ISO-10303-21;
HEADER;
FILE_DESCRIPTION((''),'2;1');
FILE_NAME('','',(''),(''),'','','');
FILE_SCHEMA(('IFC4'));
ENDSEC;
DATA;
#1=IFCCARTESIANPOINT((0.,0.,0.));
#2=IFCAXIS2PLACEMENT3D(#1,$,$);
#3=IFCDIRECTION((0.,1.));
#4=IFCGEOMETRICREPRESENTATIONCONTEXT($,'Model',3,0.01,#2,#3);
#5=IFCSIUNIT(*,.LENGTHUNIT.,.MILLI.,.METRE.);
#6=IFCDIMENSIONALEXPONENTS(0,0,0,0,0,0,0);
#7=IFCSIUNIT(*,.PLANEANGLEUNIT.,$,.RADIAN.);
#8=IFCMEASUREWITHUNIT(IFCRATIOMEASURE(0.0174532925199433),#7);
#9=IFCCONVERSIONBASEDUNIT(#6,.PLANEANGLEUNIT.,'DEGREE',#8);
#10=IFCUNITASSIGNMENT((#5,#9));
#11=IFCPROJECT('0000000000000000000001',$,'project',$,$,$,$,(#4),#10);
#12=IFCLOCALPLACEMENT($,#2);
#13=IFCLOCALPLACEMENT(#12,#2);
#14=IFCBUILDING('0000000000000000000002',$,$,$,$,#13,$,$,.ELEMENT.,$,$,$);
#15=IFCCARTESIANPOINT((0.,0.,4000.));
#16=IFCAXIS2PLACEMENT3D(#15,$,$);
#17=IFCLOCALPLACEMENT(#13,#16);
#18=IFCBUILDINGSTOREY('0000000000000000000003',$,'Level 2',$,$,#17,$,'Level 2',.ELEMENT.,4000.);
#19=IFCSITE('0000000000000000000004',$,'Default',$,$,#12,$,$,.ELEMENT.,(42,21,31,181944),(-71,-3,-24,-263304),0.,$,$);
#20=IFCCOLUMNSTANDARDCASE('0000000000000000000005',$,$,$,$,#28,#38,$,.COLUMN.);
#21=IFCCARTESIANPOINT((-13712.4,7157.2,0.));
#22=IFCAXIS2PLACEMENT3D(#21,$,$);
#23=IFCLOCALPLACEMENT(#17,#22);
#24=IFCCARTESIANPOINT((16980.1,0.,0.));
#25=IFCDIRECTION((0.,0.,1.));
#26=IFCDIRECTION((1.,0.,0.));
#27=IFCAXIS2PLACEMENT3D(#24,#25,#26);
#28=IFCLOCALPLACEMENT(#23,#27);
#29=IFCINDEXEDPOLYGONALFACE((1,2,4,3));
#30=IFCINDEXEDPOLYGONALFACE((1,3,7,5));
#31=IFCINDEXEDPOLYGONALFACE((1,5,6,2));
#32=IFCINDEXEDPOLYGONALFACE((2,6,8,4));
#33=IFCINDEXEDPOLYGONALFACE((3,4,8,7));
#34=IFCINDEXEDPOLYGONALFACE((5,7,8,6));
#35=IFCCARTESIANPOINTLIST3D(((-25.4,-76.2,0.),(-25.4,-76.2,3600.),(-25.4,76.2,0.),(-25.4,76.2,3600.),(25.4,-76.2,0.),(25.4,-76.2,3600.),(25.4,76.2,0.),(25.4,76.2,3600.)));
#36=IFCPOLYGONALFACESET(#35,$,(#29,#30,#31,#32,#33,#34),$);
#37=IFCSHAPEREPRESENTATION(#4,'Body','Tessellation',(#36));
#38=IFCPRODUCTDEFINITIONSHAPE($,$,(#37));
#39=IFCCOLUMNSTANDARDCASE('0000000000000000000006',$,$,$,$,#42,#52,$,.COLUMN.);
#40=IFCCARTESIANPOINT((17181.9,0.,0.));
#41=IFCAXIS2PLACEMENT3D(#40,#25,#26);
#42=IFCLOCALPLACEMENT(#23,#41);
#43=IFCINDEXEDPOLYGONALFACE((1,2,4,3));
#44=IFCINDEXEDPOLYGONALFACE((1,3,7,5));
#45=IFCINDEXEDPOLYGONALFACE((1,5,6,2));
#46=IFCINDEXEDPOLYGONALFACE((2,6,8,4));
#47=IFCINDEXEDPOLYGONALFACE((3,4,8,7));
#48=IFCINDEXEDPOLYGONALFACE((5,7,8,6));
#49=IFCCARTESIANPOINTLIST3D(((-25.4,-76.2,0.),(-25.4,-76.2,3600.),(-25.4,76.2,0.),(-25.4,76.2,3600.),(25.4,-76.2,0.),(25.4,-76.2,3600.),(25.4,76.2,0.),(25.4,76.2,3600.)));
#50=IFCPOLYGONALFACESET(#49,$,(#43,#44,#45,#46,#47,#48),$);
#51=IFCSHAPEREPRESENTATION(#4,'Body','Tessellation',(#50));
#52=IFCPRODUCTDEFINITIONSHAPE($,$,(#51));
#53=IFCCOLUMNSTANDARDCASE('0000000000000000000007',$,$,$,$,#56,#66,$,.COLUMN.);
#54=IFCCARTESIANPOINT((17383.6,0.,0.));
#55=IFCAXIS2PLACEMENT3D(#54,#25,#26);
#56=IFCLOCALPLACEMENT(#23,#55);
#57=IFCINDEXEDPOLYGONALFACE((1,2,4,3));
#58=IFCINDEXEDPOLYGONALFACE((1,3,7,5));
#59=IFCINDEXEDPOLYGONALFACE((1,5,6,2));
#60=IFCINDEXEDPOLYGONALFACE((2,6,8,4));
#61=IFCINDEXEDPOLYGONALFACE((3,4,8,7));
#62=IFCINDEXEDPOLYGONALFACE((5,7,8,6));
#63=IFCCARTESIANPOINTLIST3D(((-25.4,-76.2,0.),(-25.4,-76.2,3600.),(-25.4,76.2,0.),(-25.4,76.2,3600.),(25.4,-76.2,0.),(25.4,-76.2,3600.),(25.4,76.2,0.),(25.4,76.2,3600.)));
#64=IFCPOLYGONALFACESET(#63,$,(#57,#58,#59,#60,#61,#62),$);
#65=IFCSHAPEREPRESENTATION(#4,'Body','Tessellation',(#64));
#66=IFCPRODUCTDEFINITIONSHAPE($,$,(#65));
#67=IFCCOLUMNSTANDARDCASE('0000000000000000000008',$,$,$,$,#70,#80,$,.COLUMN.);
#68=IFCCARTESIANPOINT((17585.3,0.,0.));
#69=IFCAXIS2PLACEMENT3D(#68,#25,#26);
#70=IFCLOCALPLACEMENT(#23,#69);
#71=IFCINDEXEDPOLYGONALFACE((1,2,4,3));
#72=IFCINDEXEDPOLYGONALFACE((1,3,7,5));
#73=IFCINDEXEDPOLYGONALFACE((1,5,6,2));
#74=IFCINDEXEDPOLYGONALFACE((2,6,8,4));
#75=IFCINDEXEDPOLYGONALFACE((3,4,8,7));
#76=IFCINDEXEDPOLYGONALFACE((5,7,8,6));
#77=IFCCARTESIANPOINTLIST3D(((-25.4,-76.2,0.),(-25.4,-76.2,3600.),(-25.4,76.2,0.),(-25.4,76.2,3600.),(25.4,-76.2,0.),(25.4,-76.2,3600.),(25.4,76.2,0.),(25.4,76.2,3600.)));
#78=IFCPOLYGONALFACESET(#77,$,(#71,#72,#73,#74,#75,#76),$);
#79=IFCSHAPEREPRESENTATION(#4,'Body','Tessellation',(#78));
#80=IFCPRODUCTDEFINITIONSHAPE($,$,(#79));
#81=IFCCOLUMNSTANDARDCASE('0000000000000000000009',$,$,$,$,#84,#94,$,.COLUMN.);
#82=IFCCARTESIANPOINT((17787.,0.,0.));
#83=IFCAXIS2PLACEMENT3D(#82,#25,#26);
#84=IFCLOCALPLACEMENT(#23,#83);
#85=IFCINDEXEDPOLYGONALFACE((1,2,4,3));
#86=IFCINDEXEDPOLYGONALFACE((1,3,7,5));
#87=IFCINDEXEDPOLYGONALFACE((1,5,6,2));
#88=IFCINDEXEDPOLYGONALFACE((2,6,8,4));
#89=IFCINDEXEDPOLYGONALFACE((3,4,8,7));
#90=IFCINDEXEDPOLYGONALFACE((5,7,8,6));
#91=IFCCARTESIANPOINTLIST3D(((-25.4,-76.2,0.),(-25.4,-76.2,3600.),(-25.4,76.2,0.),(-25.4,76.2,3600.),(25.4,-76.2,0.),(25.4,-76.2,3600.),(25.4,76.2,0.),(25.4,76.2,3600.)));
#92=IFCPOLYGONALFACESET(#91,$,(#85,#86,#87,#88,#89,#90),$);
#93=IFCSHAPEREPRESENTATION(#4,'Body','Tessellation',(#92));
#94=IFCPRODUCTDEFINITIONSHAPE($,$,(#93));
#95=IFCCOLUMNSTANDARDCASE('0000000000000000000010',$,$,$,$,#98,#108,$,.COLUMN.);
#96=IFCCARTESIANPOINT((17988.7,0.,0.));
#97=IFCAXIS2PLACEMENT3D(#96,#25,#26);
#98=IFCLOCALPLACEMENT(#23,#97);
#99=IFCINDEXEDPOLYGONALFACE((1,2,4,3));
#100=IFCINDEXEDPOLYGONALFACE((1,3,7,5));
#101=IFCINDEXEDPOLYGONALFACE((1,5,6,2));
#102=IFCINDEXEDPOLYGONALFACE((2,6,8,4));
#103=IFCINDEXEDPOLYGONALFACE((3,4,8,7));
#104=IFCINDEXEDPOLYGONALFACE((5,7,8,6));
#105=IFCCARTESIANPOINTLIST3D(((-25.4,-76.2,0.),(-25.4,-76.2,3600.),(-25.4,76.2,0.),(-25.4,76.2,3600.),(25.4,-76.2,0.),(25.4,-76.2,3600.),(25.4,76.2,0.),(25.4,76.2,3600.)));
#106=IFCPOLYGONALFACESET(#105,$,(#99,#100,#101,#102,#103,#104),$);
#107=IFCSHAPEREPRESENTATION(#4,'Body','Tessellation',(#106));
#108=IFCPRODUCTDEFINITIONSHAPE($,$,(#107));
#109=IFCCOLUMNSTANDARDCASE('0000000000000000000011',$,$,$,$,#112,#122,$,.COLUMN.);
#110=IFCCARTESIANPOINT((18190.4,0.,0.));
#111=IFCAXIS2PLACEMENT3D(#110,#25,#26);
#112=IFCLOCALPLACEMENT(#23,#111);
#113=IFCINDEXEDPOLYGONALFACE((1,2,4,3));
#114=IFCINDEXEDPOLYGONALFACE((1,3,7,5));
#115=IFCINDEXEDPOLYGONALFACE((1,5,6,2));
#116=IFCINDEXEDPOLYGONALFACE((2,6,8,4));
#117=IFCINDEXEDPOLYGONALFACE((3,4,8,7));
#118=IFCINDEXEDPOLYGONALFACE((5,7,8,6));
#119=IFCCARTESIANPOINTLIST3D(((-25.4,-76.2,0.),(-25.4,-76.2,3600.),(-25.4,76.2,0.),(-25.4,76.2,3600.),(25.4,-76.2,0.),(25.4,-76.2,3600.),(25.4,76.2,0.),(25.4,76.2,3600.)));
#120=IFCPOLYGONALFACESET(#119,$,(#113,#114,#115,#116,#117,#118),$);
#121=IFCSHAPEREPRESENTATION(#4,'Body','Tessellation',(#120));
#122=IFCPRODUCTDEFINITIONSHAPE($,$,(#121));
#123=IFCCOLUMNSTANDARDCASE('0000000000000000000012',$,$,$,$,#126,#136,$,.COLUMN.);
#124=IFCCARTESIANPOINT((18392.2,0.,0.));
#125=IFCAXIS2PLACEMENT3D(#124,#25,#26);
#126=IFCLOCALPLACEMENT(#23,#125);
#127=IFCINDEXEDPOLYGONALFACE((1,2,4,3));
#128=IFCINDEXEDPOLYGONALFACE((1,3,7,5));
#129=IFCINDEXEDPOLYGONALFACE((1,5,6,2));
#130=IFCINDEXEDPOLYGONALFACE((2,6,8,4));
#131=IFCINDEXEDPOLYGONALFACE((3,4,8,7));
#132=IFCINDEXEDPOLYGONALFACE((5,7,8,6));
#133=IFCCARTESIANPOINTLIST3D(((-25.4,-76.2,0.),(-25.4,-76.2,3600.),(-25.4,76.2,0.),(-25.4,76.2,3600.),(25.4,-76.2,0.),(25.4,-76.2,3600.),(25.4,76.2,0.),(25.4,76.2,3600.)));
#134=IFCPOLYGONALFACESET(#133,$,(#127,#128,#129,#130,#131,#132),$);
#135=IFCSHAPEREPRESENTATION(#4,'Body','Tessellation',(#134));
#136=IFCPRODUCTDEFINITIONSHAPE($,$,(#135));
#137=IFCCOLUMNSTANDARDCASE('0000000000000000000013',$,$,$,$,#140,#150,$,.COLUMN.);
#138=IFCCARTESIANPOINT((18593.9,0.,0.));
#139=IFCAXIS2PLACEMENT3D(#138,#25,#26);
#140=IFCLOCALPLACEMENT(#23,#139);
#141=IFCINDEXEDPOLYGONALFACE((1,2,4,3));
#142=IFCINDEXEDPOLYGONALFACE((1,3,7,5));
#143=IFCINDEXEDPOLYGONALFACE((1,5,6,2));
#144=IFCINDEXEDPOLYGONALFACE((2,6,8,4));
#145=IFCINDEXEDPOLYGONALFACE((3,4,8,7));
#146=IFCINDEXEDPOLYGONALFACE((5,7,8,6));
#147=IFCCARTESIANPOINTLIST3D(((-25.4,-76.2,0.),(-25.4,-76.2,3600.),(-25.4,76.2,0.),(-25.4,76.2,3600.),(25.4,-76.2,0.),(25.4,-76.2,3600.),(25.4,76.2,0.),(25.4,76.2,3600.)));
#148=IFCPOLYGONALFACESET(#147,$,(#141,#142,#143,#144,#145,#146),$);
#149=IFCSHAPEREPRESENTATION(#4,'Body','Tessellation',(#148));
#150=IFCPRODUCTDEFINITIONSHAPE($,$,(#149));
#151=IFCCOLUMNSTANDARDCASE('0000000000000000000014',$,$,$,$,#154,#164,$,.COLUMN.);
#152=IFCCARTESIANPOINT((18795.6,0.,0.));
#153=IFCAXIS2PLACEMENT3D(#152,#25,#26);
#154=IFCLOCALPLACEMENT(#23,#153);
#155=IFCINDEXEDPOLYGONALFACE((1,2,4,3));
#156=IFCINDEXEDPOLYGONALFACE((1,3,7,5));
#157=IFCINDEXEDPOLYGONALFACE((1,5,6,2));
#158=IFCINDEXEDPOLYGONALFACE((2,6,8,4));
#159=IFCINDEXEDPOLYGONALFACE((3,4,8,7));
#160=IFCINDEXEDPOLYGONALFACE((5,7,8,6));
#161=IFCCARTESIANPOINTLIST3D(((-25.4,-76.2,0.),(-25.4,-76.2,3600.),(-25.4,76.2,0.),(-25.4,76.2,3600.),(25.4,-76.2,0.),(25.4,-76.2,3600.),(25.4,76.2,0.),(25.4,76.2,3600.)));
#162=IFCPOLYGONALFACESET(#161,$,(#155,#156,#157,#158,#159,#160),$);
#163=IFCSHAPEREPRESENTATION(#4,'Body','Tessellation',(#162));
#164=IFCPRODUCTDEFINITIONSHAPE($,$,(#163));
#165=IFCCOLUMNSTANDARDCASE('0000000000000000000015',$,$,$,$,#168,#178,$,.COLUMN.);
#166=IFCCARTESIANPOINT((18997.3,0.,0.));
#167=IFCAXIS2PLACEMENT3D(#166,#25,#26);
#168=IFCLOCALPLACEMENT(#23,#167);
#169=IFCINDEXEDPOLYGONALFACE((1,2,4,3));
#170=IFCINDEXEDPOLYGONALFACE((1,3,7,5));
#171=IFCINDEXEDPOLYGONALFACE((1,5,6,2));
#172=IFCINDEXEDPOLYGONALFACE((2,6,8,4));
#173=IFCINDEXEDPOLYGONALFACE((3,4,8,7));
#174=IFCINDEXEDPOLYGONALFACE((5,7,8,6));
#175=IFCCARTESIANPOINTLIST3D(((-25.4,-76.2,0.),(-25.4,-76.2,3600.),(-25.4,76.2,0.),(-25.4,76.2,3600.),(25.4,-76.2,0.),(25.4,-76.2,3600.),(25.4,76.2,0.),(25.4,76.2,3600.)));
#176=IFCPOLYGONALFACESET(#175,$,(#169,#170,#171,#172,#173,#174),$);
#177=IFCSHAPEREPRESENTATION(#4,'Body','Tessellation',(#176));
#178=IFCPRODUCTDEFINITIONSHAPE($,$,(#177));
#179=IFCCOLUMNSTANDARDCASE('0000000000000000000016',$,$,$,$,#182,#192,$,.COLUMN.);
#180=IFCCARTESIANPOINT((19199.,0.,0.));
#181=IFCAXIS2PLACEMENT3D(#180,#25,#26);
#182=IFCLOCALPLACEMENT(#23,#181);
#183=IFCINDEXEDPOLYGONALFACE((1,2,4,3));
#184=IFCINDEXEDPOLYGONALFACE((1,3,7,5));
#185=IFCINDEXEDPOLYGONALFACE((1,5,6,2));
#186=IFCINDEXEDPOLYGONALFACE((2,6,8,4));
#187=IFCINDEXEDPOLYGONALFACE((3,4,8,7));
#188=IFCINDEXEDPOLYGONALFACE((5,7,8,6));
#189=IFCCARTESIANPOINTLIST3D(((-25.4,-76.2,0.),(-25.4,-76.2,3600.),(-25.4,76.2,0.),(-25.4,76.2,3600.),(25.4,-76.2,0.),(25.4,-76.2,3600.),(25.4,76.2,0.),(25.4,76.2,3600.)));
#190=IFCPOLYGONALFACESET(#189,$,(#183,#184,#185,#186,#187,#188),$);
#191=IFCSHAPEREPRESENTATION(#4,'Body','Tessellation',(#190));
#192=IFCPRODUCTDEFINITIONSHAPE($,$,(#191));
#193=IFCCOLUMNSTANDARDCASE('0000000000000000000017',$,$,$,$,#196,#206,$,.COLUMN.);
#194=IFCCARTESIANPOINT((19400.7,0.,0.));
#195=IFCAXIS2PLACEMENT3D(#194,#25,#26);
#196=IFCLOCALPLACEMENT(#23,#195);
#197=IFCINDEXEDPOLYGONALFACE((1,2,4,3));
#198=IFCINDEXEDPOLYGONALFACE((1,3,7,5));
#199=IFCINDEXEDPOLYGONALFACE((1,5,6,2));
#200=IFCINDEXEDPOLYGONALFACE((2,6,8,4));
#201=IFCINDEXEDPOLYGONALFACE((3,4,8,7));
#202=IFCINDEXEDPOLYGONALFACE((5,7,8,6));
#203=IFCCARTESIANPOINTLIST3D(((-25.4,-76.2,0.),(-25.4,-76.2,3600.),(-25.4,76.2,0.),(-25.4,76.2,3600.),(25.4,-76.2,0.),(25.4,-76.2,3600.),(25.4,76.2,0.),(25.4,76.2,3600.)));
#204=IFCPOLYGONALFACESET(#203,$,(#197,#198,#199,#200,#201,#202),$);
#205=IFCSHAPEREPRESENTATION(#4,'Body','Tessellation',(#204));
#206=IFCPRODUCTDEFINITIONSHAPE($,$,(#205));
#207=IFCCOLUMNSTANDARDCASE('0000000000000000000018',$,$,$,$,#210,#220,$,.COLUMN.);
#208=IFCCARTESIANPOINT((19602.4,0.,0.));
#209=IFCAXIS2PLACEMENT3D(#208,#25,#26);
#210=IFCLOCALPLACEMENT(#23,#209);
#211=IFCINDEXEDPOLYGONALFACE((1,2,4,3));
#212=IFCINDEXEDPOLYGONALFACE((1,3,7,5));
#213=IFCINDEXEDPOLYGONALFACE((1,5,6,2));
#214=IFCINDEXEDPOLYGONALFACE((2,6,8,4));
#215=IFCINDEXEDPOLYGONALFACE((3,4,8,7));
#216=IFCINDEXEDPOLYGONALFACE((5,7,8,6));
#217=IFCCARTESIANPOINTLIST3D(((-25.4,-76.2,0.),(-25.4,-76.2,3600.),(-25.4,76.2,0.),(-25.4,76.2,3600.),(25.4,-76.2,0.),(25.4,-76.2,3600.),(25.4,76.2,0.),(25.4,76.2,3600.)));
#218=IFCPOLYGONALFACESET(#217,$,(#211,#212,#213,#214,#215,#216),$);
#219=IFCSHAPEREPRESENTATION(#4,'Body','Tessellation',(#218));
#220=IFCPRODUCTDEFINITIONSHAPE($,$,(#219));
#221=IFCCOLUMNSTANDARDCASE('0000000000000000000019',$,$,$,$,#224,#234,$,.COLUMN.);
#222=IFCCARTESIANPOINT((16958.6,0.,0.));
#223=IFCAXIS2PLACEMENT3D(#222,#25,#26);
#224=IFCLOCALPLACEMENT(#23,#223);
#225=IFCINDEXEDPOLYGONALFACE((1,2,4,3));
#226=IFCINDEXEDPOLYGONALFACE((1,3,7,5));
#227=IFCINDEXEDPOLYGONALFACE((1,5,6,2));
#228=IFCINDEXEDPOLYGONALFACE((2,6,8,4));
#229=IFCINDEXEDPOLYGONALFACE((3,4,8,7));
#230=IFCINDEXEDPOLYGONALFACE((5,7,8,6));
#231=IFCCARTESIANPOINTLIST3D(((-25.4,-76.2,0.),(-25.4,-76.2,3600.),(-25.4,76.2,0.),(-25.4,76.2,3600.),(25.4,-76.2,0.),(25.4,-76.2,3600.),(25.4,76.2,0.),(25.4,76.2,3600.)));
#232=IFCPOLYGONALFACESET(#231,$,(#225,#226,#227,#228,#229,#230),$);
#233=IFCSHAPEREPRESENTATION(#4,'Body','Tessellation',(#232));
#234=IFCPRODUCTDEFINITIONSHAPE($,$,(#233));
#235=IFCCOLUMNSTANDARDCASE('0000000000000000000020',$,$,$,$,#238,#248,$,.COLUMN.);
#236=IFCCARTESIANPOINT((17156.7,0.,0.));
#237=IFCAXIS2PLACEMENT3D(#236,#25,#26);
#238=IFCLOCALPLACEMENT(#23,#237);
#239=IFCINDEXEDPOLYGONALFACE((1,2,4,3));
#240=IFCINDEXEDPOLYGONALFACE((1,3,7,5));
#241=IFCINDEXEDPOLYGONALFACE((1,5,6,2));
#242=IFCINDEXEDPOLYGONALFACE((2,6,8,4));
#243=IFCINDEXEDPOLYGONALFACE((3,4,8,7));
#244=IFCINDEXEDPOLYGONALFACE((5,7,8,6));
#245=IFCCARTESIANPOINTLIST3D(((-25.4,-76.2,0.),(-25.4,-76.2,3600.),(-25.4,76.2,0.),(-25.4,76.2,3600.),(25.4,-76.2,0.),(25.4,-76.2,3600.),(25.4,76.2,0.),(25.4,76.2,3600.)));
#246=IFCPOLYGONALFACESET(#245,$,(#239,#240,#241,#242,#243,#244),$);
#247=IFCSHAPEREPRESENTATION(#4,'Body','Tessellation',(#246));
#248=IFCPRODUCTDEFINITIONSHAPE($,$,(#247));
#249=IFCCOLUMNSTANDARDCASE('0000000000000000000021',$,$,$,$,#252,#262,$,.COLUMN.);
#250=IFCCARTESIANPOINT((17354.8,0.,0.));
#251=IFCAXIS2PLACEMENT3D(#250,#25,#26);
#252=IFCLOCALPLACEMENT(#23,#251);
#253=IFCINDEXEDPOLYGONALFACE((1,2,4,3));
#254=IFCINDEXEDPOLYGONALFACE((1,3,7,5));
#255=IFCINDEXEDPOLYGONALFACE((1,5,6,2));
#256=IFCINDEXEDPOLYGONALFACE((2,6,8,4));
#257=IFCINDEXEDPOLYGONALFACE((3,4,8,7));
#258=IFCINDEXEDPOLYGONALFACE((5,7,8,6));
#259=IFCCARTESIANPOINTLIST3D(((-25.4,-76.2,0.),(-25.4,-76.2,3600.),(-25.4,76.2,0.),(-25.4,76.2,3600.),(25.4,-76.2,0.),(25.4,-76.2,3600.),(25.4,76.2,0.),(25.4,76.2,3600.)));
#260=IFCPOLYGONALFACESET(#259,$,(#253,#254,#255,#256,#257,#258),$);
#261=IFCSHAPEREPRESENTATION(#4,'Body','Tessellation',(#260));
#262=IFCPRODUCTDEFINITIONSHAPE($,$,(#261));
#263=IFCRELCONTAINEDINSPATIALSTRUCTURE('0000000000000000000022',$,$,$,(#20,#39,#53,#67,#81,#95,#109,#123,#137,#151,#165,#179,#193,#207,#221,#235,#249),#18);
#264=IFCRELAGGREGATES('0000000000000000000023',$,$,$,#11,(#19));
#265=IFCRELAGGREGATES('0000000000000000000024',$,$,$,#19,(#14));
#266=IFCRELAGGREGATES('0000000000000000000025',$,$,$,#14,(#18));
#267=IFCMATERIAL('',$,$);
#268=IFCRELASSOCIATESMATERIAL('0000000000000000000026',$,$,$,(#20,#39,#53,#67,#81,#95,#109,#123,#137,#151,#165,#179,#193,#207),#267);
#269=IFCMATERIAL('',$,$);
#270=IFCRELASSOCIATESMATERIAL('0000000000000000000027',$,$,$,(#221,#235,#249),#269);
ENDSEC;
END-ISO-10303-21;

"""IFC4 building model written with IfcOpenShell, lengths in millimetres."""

from ifc_helpers import new_model, entity, si_unit, converted_unit, direction, frame, origin, place, context, project, spatial, rectangle, extrude, material, element, save


model = new_model("IFC4")

# Units and contexts
model_context = context("Model", 3, precision=0.01, world=origin(), true_north=direction((0.0, 1.0)))
ifc_project = project(units=[si_unit("LENGTHUNIT", "METRE", prefix="MILLI"), converted_unit("PLANEANGLEUNIT", "DEGREE", entity("IfcRatioMeasure", 0.0174532925199433), si_unit("PLANEANGLEUNIT", "RADIAN"), dimensions=[0, 0, 0, 0, 0, 0, 0])], contexts=[model_context])

# Site, building, storey
site_placement = place(None, origin())
site = spatial("IfcSite", under=ifc_project, at=site_placement, Name="Default", CompositionType="ELEMENT", RefLatitude=(42, 21, 31, 181944), RefLongitude=(-71, -3, -24, -263304), RefElevation=0.0)
building_placement = place(site_placement, origin())
building = spatial("IfcBuilding", under=site, at=building_placement, CompositionType="ELEMENT")
storey_placement = place(building_placement, frame((0.0, 0.0, 4000.0)))
storey = spatial("IfcBuildingStorey", under=building, at=storey_placement, Name="Level 2", LongName="Level 2", CompositionType="ELEMENT", Elevation=4000.0)

# Columns
ifc_material_1 = material(Name="")
placement_1 = place(storey_placement, frame((-13712.4, 7157.2, 0.0)))
for number, where, z_axis, x_axis in (
    (1, (16980.1, 0.0, 0.0), (0.0, 0.0, 1.0), (1.0, 0.0, 0.0)),
    (2, (17181.9, 0.0, 0.0), (0.0, 0.0, 1.0), (1.0, 0.0, 0.0)),
    (3, (17383.6, 0.0, 0.0), (0.0, 0.0, 1.0), (1.0, 0.0, 0.0)),
    (4, (17585.3, 0.0, 0.0), (0.0, 0.0, 1.0), (1.0, 0.0, 0.0)),
    (5, (17787.0, 0.0, 0.0), (0.0, 0.0, 1.0), (1.0, 0.0, 0.0)),
    (6, (17988.7, 0.0, 0.0), (0.0, 0.0, 1.0), (1.0, 0.0, 0.0)),
    (7, (18190.4, 0.0, 0.0), (0.0, 0.0, 1.0), (1.0, 0.0, 0.0)),
    (8, (18392.2, 0.0, 0.0), (0.0, 0.0, 1.0), (1.0, 0.0, 0.0)),
    (9, (18593.9, 0.0, 0.0), (0.0, 0.0, 1.0), (1.0, 0.0, 0.0)),
    (10, (18795.6, 0.0, 0.0), (0.0, 0.0, 1.0), (1.0, 0.0, 0.0)),
    (11, (18997.3, 0.0, 0.0), (0.0, 0.0, 1.0), (1.0, 0.0, 0.0)),
    (12, (19199.0, 0.0, 0.0), (0.0, 0.0, 1.0), (1.0, 0.0, 0.0)),
    (13, (19400.7, 0.0, 0.0), (0.0, 0.0, 1.0), (1.0, 0.0, 0.0)),
    (14, (19602.4, 0.0, 0.0), (0.0, 0.0, 1.0), (1.0, 0.0, 0.0)),
):
    element("IfcColumnStandardCase", number, at=place(placement_1, frame(where, z_axis=z_axis, x_axis=x_axis)), inside=storey, material=ifc_material_1, PredefinedType="COLUMN", context=model_context, shape_type="SweptSolid", body=[
        extrude(rectangle(XDim=50.8, YDim=152.4), origin(), (0.0, 0.0, 1.0), 3600.0),
    ])
ifc_material_2 = material(Name="")
for number, where, z_axis, x_axis in (
    (15, (16958.6, 0.0, 0.0), (0.0, 0.0, 1.0), (1.0, 0.0, 0.0)),
    (16, (17156.7, 0.0, 0.0), (0.0, 0.0, 1.0), (1.0, 0.0, 0.0)),
    (17, (17354.8, 0.0, 0.0), (0.0, 0.0, 1.0), (1.0, 0.0, 0.0)),
):
    element("IfcColumnStandardCase", number, at=place(placement_1, frame(where, z_axis=z_axis, x_axis=x_axis)), inside=storey, material=ifc_material_2, PredefinedType="COLUMN", context=model_context, shape_type="SweptSolid", body=[
        extrude(rectangle(XDim=50.8, YDim=152.4), origin(), (0.0, 0.0, 1.0), 3600.0),
    ])

save(model, "model.ifc")
